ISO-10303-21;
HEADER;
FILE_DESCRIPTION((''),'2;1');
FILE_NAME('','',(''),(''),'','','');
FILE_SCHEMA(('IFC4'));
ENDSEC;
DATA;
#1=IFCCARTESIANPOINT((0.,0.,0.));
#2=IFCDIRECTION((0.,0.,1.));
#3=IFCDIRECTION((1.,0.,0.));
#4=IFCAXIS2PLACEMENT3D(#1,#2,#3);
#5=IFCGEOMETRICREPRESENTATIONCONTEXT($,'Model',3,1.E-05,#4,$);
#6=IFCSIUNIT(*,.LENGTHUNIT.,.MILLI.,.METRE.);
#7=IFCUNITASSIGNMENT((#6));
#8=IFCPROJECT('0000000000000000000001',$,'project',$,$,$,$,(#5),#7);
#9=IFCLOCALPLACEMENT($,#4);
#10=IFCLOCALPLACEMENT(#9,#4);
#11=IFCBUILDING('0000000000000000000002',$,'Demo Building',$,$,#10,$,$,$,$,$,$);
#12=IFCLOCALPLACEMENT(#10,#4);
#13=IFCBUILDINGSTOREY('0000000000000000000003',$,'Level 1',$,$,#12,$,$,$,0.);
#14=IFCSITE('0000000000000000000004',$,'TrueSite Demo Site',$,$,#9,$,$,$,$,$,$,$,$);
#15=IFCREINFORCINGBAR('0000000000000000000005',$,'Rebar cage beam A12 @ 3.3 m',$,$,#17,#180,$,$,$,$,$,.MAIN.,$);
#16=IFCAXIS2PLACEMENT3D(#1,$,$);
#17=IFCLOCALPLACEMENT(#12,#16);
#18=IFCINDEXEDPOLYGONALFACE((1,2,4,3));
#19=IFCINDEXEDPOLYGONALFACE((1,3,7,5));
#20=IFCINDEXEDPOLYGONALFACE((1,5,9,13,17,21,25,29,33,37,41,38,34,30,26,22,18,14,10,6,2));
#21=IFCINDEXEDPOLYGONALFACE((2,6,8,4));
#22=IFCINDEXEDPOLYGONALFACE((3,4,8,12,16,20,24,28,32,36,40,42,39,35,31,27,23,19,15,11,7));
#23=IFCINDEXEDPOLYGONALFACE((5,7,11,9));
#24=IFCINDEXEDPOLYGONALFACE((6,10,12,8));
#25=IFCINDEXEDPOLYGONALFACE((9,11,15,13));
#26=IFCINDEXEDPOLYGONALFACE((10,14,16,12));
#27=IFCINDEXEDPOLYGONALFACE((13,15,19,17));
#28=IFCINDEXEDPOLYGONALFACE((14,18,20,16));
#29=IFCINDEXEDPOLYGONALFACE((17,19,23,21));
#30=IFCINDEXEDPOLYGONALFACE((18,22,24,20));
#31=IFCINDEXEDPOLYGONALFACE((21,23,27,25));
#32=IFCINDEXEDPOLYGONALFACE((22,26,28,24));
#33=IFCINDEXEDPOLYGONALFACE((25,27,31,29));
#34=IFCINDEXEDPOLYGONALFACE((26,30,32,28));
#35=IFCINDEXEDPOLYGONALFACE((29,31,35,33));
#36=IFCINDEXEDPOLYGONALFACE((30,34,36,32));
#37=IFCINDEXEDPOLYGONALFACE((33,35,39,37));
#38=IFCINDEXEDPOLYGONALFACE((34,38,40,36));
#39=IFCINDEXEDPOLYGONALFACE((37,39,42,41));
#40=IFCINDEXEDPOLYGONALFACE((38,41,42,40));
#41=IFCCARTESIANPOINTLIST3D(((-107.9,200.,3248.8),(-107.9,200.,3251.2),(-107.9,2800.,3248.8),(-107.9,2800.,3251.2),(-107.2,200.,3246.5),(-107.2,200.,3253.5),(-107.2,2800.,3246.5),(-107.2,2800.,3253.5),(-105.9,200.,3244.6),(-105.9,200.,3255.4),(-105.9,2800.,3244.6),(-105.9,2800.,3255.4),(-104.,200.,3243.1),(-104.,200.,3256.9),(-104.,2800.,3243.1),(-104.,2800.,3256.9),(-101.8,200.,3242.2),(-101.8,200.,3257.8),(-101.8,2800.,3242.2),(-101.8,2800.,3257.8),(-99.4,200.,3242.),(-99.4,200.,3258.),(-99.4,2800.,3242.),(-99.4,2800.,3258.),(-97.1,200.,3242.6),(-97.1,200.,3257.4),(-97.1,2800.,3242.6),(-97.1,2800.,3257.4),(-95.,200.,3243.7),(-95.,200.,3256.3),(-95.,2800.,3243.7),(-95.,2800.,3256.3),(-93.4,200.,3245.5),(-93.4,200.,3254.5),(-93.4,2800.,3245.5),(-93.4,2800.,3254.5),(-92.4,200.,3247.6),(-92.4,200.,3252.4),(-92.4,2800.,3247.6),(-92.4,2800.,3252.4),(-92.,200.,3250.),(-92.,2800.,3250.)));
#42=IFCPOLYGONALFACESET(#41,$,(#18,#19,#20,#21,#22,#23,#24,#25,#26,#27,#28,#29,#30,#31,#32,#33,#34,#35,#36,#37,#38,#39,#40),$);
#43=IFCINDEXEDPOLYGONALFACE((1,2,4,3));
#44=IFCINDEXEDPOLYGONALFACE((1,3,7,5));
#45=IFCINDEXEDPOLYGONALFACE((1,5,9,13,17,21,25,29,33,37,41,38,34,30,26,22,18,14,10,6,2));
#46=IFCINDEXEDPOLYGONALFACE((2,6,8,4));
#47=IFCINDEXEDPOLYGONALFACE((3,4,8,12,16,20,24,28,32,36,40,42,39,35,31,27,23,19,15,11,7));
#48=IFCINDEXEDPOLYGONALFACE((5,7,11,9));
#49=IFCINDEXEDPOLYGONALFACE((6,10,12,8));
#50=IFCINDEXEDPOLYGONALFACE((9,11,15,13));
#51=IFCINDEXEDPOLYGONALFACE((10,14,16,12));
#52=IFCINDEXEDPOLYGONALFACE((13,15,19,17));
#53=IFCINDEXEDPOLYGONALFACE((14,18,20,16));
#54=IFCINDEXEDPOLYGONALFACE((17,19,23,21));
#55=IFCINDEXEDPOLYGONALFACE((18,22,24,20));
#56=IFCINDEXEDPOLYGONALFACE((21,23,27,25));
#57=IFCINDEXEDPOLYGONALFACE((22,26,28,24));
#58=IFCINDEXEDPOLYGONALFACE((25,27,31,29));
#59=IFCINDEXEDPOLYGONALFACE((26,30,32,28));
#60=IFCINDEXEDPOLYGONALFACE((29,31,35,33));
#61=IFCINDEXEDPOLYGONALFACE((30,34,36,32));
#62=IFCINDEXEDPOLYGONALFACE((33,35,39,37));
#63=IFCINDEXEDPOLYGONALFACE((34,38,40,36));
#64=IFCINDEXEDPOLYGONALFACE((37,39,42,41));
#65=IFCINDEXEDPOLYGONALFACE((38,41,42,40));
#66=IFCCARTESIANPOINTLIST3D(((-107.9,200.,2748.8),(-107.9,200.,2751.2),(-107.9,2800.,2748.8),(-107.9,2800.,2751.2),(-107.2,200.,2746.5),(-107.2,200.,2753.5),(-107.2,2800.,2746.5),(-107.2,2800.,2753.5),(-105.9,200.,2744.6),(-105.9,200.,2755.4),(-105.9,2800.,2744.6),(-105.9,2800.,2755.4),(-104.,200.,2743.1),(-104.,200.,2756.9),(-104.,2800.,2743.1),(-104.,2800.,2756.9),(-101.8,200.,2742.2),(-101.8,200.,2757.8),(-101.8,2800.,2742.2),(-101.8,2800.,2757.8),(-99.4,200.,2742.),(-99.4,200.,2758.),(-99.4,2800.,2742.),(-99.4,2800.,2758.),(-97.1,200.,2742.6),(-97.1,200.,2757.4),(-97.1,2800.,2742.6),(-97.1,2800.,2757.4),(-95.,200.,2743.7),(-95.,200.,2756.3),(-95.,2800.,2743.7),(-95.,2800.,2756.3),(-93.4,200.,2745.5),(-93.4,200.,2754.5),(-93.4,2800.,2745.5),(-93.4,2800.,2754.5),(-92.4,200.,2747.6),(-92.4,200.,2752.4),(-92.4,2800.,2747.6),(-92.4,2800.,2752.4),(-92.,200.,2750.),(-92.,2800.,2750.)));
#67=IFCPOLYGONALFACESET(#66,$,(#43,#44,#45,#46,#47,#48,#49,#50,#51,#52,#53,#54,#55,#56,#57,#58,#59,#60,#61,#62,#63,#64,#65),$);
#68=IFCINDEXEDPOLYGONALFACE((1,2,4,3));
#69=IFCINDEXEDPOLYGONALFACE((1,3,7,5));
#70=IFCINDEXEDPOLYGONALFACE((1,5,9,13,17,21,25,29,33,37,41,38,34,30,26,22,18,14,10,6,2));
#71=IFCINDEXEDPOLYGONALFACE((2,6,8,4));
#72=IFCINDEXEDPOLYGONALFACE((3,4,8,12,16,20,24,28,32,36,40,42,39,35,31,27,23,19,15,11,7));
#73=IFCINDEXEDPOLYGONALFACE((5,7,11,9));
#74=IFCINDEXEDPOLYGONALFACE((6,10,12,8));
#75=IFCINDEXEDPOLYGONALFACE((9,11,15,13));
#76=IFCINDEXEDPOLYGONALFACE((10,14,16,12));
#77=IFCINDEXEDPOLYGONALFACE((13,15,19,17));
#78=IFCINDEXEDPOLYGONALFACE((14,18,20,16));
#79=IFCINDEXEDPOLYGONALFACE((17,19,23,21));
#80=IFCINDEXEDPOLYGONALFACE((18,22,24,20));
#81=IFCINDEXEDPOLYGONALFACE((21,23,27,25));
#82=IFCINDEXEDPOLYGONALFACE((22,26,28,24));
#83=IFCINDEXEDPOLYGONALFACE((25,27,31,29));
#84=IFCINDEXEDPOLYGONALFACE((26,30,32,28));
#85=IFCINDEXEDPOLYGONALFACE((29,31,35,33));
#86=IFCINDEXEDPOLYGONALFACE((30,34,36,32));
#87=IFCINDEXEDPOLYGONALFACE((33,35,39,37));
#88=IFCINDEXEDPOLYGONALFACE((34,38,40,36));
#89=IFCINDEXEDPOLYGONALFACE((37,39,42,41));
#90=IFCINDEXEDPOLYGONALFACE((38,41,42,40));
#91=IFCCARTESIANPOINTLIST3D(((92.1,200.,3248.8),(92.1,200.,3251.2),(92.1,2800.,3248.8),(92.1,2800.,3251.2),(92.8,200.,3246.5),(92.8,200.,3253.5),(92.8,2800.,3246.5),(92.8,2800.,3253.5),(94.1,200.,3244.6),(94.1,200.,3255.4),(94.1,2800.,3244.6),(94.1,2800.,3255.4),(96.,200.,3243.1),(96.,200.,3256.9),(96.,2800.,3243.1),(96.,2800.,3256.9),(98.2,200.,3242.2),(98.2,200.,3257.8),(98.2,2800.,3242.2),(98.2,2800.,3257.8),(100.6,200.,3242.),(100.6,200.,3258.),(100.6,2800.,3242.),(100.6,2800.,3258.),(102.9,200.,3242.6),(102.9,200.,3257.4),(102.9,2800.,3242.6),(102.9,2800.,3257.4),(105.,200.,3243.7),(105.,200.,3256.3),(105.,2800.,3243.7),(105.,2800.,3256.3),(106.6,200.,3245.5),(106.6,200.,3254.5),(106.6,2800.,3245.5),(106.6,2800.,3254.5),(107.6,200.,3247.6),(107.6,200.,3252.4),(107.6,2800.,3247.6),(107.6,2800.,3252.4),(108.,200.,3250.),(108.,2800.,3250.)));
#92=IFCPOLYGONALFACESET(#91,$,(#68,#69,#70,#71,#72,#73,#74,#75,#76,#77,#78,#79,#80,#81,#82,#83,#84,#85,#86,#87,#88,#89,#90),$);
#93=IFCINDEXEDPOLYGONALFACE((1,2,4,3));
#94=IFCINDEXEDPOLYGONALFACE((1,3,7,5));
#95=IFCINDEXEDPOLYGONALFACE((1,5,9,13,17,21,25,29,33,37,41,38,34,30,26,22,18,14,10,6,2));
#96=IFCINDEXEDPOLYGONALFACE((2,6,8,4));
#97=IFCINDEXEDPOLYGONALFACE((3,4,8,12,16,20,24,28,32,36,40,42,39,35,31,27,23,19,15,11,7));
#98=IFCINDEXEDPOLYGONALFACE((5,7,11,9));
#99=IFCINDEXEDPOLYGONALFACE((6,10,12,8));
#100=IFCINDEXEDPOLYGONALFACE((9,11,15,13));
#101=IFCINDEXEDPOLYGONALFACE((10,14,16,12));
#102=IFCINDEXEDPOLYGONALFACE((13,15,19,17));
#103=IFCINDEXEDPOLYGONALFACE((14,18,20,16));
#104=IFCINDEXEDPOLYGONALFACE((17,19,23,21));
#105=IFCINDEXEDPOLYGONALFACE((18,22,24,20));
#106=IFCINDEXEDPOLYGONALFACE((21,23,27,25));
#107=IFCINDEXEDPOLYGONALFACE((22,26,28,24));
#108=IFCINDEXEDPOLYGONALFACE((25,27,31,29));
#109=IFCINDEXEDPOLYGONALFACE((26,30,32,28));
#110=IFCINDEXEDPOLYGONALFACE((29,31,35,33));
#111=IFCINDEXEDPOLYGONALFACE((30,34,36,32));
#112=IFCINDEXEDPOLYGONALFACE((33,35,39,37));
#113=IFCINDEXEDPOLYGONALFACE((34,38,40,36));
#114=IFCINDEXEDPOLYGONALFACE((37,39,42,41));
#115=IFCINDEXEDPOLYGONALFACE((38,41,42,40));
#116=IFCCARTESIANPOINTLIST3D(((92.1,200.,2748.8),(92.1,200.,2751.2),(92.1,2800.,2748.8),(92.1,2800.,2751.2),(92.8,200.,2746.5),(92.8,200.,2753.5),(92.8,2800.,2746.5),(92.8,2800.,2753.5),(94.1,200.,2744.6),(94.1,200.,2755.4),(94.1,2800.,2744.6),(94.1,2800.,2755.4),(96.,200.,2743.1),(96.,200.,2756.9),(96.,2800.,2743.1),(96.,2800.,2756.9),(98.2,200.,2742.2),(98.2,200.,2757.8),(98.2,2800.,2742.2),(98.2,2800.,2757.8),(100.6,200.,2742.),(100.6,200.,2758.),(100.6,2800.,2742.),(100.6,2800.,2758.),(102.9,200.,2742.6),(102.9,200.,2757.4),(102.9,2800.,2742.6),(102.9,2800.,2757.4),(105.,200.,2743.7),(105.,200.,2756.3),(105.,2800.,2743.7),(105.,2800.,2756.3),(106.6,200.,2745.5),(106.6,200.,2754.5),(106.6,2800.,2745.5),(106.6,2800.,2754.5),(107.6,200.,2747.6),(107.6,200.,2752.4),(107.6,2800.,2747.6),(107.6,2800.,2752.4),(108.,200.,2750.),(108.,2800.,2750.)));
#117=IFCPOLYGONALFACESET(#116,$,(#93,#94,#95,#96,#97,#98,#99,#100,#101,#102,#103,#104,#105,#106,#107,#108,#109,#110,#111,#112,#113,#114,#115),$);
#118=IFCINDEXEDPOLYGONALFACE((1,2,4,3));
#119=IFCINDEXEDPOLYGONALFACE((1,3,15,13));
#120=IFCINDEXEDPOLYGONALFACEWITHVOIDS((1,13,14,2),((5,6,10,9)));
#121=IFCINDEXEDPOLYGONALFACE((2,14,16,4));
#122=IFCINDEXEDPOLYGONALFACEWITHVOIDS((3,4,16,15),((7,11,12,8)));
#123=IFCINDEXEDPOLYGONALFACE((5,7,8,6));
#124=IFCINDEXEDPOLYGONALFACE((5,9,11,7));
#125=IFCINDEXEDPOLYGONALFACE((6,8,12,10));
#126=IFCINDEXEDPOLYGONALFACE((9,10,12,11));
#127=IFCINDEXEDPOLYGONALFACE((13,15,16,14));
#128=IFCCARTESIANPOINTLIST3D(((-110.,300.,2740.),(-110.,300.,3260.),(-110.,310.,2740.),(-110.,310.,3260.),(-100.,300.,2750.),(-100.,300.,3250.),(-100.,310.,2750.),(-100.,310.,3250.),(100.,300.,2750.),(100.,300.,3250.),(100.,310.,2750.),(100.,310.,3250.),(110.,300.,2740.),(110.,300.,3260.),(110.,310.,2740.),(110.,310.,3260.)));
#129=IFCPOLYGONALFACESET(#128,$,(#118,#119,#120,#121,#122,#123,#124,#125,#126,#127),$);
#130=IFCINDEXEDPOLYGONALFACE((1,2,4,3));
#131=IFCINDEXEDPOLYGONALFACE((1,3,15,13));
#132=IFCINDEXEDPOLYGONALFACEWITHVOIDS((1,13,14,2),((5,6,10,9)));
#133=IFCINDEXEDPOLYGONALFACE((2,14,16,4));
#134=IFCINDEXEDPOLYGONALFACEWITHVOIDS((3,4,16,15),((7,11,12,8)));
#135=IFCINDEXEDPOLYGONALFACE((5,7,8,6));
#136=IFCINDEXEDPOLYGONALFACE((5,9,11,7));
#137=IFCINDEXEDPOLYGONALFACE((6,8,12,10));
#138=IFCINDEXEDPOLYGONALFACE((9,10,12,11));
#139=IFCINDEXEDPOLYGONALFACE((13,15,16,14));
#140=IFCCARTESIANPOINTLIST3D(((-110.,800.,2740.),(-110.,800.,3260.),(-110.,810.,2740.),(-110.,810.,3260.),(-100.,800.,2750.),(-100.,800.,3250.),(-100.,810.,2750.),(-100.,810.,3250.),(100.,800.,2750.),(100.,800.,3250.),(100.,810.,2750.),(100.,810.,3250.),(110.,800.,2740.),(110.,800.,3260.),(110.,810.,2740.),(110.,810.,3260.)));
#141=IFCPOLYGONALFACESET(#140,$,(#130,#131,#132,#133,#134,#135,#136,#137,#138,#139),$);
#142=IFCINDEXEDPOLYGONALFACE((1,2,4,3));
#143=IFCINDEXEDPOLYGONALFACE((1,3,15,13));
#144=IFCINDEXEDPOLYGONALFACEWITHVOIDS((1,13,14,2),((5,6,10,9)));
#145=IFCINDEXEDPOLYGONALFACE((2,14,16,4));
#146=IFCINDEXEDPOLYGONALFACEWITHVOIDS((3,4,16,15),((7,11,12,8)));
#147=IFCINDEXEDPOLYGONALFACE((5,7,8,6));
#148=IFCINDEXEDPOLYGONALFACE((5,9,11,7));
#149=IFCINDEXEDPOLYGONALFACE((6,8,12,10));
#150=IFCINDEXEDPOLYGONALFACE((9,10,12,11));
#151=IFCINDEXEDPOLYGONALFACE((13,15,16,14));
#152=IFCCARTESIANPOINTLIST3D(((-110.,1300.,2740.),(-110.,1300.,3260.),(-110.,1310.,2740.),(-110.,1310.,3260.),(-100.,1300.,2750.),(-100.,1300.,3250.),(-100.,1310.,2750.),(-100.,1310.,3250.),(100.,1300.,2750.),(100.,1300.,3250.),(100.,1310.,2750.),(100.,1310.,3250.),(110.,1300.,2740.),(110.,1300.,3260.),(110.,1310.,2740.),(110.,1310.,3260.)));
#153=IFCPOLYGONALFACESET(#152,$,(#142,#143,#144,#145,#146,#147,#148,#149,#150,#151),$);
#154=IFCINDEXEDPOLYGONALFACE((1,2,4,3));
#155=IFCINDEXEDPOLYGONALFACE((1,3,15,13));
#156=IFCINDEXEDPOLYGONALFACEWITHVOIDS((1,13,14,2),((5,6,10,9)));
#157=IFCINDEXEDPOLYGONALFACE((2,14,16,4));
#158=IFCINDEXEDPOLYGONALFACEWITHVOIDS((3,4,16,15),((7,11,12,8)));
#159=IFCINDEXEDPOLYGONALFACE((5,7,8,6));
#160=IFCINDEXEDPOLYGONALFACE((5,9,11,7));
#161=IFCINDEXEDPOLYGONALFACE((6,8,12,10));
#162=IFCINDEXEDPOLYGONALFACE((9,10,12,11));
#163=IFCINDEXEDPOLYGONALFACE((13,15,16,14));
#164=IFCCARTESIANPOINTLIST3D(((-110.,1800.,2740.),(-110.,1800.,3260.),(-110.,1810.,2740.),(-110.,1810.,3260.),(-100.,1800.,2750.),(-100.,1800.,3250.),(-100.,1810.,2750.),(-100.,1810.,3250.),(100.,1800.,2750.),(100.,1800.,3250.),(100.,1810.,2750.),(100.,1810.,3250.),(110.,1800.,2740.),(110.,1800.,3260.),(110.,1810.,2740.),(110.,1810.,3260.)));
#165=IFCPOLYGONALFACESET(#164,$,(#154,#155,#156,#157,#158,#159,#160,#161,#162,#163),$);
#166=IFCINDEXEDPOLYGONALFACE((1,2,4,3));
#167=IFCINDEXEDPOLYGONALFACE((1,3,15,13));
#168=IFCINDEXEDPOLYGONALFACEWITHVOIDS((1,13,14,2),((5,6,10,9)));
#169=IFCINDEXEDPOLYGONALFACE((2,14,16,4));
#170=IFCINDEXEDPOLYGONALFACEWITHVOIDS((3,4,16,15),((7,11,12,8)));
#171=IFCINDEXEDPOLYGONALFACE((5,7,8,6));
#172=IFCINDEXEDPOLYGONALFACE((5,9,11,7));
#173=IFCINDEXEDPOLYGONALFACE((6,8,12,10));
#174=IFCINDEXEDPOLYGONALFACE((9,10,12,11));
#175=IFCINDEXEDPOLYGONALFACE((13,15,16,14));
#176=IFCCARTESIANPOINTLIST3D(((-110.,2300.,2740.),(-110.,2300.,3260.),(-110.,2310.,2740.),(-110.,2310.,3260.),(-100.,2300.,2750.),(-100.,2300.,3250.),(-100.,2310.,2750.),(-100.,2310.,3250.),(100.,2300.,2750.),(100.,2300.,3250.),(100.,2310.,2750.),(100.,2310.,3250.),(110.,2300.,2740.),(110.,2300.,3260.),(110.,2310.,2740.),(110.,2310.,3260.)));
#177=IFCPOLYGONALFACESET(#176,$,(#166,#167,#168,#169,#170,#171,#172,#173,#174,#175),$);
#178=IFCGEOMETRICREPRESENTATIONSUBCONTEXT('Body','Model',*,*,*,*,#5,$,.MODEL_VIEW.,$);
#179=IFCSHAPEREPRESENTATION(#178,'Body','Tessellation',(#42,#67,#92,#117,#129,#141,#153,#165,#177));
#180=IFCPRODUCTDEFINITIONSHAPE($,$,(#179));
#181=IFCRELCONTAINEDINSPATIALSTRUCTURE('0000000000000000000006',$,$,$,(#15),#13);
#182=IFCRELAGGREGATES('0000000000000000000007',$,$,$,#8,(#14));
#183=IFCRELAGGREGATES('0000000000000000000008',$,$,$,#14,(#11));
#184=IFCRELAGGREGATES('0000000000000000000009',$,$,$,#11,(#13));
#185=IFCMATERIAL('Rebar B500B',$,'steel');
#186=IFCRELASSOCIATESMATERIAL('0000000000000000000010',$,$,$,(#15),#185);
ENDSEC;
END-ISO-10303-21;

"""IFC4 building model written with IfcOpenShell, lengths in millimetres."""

from ifc_helpers import new_model, si_unit, frame, origin_with_axes, place, context, subcontext, project, spatial, hollow_rectangle, circle, extrude, material, element, save


model = new_model("IFC4")

# Units and contexts
model_context = context("Model", 3, precision=1e-05, world=origin_with_axes())
body_context = subcontext(model_context, "Body", "Model", "MODEL_VIEW")
ifc_project = project(units=[si_unit("LENGTHUNIT", "METRE", prefix="MILLI")], contexts=[model_context])

# Site, building, storey
site_placement = place(None, origin_with_axes())
site = spatial("IfcSite", under=ifc_project, at=site_placement, Name="TrueSite Demo Site")
building_placement = place(site_placement, origin_with_axes())
building = spatial("IfcBuilding", under=site, at=building_placement, Name="Demo Building")
storey_placement = place(building_placement, origin_with_axes())
storey = spatial("IfcBuildingStorey", under=building, at=storey_placement, Name="Level 1", Elevation=0.0)

# Reinforcing bar
ifc_material_1 = material(Name="Rebar B500B", Category="steel")
for number, where, z_axis, x_axis, name in (
    (1, (0.0, 200.0, 3000.0), (0.0, 1.0, 0.0), (1.0, 0.0, 0.0), "Rebar cage beam A12 @ 3.3 m"),
):
    element("IfcReinforcingBar", number, at=place(storey_placement, frame(where, z_axis=z_axis, x_axis=x_axis)), inside=storey, material=ifc_material_1, Name=name, PredefinedType="MAIN", context=body_context, shape_type="SweptSolid", body=[
        extrude(circle(Radius=8.0), frame((-100.0, -250.0, 0.0)), (0.0, 0.0, 1.0), 2600.0),
        extrude(circle(Radius=8.0), frame((-100.0, 250.0, 0.0)), (0.0, 0.0, 1.0), 2600.0),
        extrude(circle(Radius=8.0), frame((100.0, -250.0, 0.0)), (0.0, 0.0, 1.0), 2600.0),
        extrude(circle(Radius=8.0), frame((100.0, 250.0, 0.0)), (0.0, 0.0, 1.0), 2600.0),
        extrude(hollow_rectangle(XDim=220.0, YDim=520.0, WallThickness=10.0), frame((0.0, 0.0, 100.0)), (0.0, 0.0, 1.0), 10.0),
        extrude(hollow_rectangle(XDim=220.0, YDim=520.0, WallThickness=10.0), frame((0.0, 0.0, 600.0)), (0.0, 0.0, 1.0), 10.0),
        extrude(hollow_rectangle(XDim=220.0, YDim=520.0, WallThickness=10.0), frame((0.0, 0.0, 1100.0)), (0.0, 0.0, 1.0), 10.0),
        extrude(hollow_rectangle(XDim=220.0, YDim=520.0, WallThickness=10.0), frame((0.0, 0.0, 1600.0)), (0.0, 0.0, 1.0), 10.0),
        extrude(hollow_rectangle(XDim=220.0, YDim=520.0, WallThickness=10.0), frame((0.0, 0.0, 2100.0)), (0.0, 0.0, 1.0), 10.0),
    ])

save(model, "model.ifc")
